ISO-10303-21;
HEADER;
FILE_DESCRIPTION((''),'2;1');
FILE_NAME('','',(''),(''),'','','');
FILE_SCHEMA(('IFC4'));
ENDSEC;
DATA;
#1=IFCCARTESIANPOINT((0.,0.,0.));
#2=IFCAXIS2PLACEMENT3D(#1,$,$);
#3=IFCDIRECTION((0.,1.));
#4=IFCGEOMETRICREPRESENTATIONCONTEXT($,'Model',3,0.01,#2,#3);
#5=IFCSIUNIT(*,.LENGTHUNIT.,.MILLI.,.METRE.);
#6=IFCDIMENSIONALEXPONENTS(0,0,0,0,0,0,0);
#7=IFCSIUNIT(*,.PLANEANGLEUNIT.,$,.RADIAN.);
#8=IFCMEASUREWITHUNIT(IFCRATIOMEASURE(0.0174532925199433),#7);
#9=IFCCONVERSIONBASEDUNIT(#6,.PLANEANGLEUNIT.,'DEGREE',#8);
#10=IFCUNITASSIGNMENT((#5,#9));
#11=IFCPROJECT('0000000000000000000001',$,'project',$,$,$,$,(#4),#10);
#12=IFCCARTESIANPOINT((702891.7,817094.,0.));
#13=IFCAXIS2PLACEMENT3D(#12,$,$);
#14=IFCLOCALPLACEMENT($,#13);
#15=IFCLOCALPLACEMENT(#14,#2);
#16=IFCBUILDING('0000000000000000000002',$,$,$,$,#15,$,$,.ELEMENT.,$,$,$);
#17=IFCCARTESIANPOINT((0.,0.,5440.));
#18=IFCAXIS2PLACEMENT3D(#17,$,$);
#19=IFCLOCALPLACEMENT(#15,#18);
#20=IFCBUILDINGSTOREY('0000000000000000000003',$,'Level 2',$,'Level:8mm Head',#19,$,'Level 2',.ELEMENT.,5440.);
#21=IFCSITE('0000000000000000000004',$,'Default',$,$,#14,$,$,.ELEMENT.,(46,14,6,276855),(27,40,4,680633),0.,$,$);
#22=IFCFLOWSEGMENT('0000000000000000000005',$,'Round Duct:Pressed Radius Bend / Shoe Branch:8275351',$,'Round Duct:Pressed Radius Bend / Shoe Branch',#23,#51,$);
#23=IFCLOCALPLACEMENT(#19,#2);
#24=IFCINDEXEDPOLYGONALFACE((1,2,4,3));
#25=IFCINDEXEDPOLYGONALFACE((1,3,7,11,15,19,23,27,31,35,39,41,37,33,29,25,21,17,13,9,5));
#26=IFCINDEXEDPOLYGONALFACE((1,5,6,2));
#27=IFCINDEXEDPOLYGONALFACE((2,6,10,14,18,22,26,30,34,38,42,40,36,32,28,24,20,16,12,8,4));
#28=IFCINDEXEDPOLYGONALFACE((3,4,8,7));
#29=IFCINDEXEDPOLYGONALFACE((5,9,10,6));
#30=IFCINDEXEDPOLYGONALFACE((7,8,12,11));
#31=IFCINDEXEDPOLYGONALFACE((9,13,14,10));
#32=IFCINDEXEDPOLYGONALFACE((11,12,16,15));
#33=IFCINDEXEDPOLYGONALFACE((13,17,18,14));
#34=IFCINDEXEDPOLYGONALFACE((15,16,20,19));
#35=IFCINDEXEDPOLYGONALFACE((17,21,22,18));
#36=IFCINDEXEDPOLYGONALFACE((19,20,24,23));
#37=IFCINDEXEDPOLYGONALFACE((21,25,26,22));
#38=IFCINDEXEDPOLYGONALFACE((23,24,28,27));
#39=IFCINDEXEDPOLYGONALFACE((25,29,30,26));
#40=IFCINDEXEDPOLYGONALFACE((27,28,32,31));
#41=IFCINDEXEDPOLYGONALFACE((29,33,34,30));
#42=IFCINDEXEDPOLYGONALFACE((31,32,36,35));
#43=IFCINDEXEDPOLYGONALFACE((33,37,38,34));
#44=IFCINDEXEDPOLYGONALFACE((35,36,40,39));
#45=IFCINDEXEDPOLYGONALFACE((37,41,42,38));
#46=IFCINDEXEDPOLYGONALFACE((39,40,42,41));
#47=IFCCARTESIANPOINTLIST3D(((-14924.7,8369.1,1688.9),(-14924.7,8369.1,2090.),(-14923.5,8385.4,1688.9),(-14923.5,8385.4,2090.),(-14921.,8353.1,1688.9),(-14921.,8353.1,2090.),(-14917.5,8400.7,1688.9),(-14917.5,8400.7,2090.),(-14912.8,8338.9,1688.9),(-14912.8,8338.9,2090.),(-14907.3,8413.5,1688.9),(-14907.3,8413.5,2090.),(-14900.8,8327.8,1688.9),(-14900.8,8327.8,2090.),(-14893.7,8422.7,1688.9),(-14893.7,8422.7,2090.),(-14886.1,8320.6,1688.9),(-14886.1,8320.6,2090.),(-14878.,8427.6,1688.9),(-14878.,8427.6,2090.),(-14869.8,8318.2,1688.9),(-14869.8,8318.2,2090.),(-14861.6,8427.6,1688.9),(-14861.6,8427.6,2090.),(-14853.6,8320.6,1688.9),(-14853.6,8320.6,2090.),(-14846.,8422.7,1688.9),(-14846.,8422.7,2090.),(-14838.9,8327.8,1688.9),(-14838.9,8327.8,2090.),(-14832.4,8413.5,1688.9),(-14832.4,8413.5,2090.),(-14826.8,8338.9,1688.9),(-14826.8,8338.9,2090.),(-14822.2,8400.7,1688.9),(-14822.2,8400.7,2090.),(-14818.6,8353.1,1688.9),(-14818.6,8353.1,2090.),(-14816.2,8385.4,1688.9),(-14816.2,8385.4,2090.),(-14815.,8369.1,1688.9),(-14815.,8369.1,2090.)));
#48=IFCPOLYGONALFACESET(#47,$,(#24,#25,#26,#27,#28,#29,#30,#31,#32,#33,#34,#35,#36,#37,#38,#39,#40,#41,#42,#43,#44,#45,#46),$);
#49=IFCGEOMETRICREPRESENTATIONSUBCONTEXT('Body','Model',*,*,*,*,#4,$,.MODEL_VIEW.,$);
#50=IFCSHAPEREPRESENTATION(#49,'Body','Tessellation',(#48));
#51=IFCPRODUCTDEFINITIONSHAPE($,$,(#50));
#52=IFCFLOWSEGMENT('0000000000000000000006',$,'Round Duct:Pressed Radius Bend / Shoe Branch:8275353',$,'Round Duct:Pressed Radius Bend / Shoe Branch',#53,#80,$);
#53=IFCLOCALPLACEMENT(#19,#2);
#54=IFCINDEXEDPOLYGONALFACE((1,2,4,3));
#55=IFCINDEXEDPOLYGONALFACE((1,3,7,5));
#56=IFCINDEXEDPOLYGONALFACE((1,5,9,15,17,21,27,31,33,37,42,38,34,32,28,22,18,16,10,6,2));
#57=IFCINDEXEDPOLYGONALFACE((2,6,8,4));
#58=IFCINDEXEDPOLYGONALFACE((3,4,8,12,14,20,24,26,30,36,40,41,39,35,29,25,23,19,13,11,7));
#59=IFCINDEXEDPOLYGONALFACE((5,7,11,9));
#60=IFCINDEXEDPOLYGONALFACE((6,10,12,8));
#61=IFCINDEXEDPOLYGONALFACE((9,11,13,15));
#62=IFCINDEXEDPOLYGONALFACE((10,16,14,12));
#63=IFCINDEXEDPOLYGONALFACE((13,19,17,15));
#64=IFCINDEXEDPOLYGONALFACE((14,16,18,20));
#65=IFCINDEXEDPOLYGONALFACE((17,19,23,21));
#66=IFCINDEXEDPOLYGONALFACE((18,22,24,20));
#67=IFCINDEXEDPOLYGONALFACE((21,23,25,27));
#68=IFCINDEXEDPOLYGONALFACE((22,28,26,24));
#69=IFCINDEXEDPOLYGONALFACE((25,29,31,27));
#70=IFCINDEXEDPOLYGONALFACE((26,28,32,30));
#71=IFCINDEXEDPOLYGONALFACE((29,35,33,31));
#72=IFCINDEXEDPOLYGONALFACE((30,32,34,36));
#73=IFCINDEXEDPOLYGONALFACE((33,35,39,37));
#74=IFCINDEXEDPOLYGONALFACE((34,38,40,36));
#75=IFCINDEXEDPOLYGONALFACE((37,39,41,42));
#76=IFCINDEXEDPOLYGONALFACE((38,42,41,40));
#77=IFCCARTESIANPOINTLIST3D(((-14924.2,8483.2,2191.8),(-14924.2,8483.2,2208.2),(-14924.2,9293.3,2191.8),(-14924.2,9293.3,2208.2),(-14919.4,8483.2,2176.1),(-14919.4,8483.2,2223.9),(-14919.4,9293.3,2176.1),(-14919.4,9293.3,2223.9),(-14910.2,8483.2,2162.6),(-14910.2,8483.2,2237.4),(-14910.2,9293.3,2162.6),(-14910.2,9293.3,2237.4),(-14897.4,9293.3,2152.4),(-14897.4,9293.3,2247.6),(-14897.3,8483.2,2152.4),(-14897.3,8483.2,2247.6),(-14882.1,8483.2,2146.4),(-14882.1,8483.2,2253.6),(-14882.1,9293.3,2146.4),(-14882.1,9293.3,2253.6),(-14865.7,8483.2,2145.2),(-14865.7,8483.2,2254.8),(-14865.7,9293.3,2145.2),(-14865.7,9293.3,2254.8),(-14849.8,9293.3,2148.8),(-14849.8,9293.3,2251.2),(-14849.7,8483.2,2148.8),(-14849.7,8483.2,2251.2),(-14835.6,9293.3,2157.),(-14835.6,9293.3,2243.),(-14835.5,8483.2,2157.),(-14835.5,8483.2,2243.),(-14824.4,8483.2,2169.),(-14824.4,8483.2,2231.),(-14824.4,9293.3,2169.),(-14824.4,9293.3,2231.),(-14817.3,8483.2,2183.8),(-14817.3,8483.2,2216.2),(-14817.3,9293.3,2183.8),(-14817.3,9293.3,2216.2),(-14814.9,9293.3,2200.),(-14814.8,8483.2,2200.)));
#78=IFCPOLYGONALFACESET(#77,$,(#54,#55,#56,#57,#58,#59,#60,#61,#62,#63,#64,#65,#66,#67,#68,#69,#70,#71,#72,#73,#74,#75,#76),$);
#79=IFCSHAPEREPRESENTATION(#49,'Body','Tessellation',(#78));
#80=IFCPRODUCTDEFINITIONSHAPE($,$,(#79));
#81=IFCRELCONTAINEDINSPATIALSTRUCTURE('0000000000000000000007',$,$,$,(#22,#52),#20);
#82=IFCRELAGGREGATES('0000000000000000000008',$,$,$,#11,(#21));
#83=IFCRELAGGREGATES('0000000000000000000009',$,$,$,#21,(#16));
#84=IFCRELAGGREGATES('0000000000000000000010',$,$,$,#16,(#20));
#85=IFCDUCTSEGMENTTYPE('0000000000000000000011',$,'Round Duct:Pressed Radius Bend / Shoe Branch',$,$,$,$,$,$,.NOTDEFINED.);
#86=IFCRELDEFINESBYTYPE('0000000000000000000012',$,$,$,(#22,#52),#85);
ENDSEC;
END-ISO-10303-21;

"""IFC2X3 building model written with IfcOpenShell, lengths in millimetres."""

from ifc_helpers import new_model, entity, si_unit, converted_unit, direction, frame, frame_2d, origin, place, context, subcontext, project, spatial, circle, extrude, type_object, element, save


model = new_model("IFC2X3")

# Units and contexts
model_context = context("Model", 3, precision=0.01, world=origin(), true_north=direction((0.0, 1.0)))
body_context = subcontext(model_context, "Body", "Model", "MODEL_VIEW")
ifc_project = project(units=[si_unit("LENGTHUNIT", "METRE", prefix="MILLI"), converted_unit("PLANEANGLEUNIT", "DEGREE", entity("IfcRatioMeasure", 0.0174532925199433), si_unit("PLANEANGLEUNIT", "RADIAN"), dimensions=[0, 0, 0, 0, 0, 0, 0])], contexts=[model_context])

# Site, building, storey
site_placement = place(None, frame((702891.7, 817094.0, 0.0)))
site = spatial("IfcSite", under=ifc_project, at=site_placement, Name="Default", CompositionType="ELEMENT", RefLatitude=(46, 14, 6, 276855), RefLongitude=(27, 40, 4, 680633), RefElevation=0.0)
building_placement = place(site_placement, origin())
building = spatial("IfcBuilding", under=site, at=building_placement, CompositionType="ELEMENT")
storey_placement = place(building_placement, frame((0.0, 0.0, 5440.0)))
storey = spatial("IfcBuildingStorey", under=building, at=storey_placement, Name="Level 2", ObjectType="Level:8mm Head", LongName="Level 2", CompositionType="ELEMENT", Elevation=5440.0)

# Flow segments
duct_segment_type = type_object("IfcDuctSegmentType", Name="Round Duct:Pressed Radius Bend / Shoe Branch", PredefinedType="NOTDEFINED")
flow_segment_1_placement = place(storey_placement, origin())
element("IfcFlowSegment", 1, at=flow_segment_1_placement, inside=storey, type_object=duct_segment_type, Name="Round Duct:Pressed Radius Bend / Shoe Branch:8275351", ObjectType="Round Duct:Pressed Radius Bend / Shoe Branch", context=body_context, shape_type="SweptSolid", body=[
    extrude(circle(Radius=55.0, at=frame_2d((0.0, 0.0), x_axis=(1.0, 0.0))), frame((-14869.8, 8373.2, 1688.9), z_axis=(0.0, 0.0, 1.0), x_axis=(0.000024, -1.0, 0.0)), (0.0, 0.0, 1.0), 401.1),
])
flow_segment_2_placement = place(storey_placement, origin())
element("IfcFlowSegment", 2, at=flow_segment_2_placement, inside=storey, type_object=duct_segment_type, Name="Round Duct:Pressed Radius Bend / Shoe Branch:8275353", ObjectType="Round Duct:Pressed Radius Bend / Shoe Branch", context=body_context, shape_type="SweptSolid", body=[
    extrude(circle(Radius=55.0, at=frame_2d((0.0, 0.0), x_axis=(1.0, 0.0))), frame((-14869.8, 8483.2, 2200.0), z_axis=(-0.000024, 1.0, 0.0), x_axis=(1.0, 0.000024, 0.0)), (0.0, 0.0, 1.0), 810.1),
])

save(model, "model.ifc")
